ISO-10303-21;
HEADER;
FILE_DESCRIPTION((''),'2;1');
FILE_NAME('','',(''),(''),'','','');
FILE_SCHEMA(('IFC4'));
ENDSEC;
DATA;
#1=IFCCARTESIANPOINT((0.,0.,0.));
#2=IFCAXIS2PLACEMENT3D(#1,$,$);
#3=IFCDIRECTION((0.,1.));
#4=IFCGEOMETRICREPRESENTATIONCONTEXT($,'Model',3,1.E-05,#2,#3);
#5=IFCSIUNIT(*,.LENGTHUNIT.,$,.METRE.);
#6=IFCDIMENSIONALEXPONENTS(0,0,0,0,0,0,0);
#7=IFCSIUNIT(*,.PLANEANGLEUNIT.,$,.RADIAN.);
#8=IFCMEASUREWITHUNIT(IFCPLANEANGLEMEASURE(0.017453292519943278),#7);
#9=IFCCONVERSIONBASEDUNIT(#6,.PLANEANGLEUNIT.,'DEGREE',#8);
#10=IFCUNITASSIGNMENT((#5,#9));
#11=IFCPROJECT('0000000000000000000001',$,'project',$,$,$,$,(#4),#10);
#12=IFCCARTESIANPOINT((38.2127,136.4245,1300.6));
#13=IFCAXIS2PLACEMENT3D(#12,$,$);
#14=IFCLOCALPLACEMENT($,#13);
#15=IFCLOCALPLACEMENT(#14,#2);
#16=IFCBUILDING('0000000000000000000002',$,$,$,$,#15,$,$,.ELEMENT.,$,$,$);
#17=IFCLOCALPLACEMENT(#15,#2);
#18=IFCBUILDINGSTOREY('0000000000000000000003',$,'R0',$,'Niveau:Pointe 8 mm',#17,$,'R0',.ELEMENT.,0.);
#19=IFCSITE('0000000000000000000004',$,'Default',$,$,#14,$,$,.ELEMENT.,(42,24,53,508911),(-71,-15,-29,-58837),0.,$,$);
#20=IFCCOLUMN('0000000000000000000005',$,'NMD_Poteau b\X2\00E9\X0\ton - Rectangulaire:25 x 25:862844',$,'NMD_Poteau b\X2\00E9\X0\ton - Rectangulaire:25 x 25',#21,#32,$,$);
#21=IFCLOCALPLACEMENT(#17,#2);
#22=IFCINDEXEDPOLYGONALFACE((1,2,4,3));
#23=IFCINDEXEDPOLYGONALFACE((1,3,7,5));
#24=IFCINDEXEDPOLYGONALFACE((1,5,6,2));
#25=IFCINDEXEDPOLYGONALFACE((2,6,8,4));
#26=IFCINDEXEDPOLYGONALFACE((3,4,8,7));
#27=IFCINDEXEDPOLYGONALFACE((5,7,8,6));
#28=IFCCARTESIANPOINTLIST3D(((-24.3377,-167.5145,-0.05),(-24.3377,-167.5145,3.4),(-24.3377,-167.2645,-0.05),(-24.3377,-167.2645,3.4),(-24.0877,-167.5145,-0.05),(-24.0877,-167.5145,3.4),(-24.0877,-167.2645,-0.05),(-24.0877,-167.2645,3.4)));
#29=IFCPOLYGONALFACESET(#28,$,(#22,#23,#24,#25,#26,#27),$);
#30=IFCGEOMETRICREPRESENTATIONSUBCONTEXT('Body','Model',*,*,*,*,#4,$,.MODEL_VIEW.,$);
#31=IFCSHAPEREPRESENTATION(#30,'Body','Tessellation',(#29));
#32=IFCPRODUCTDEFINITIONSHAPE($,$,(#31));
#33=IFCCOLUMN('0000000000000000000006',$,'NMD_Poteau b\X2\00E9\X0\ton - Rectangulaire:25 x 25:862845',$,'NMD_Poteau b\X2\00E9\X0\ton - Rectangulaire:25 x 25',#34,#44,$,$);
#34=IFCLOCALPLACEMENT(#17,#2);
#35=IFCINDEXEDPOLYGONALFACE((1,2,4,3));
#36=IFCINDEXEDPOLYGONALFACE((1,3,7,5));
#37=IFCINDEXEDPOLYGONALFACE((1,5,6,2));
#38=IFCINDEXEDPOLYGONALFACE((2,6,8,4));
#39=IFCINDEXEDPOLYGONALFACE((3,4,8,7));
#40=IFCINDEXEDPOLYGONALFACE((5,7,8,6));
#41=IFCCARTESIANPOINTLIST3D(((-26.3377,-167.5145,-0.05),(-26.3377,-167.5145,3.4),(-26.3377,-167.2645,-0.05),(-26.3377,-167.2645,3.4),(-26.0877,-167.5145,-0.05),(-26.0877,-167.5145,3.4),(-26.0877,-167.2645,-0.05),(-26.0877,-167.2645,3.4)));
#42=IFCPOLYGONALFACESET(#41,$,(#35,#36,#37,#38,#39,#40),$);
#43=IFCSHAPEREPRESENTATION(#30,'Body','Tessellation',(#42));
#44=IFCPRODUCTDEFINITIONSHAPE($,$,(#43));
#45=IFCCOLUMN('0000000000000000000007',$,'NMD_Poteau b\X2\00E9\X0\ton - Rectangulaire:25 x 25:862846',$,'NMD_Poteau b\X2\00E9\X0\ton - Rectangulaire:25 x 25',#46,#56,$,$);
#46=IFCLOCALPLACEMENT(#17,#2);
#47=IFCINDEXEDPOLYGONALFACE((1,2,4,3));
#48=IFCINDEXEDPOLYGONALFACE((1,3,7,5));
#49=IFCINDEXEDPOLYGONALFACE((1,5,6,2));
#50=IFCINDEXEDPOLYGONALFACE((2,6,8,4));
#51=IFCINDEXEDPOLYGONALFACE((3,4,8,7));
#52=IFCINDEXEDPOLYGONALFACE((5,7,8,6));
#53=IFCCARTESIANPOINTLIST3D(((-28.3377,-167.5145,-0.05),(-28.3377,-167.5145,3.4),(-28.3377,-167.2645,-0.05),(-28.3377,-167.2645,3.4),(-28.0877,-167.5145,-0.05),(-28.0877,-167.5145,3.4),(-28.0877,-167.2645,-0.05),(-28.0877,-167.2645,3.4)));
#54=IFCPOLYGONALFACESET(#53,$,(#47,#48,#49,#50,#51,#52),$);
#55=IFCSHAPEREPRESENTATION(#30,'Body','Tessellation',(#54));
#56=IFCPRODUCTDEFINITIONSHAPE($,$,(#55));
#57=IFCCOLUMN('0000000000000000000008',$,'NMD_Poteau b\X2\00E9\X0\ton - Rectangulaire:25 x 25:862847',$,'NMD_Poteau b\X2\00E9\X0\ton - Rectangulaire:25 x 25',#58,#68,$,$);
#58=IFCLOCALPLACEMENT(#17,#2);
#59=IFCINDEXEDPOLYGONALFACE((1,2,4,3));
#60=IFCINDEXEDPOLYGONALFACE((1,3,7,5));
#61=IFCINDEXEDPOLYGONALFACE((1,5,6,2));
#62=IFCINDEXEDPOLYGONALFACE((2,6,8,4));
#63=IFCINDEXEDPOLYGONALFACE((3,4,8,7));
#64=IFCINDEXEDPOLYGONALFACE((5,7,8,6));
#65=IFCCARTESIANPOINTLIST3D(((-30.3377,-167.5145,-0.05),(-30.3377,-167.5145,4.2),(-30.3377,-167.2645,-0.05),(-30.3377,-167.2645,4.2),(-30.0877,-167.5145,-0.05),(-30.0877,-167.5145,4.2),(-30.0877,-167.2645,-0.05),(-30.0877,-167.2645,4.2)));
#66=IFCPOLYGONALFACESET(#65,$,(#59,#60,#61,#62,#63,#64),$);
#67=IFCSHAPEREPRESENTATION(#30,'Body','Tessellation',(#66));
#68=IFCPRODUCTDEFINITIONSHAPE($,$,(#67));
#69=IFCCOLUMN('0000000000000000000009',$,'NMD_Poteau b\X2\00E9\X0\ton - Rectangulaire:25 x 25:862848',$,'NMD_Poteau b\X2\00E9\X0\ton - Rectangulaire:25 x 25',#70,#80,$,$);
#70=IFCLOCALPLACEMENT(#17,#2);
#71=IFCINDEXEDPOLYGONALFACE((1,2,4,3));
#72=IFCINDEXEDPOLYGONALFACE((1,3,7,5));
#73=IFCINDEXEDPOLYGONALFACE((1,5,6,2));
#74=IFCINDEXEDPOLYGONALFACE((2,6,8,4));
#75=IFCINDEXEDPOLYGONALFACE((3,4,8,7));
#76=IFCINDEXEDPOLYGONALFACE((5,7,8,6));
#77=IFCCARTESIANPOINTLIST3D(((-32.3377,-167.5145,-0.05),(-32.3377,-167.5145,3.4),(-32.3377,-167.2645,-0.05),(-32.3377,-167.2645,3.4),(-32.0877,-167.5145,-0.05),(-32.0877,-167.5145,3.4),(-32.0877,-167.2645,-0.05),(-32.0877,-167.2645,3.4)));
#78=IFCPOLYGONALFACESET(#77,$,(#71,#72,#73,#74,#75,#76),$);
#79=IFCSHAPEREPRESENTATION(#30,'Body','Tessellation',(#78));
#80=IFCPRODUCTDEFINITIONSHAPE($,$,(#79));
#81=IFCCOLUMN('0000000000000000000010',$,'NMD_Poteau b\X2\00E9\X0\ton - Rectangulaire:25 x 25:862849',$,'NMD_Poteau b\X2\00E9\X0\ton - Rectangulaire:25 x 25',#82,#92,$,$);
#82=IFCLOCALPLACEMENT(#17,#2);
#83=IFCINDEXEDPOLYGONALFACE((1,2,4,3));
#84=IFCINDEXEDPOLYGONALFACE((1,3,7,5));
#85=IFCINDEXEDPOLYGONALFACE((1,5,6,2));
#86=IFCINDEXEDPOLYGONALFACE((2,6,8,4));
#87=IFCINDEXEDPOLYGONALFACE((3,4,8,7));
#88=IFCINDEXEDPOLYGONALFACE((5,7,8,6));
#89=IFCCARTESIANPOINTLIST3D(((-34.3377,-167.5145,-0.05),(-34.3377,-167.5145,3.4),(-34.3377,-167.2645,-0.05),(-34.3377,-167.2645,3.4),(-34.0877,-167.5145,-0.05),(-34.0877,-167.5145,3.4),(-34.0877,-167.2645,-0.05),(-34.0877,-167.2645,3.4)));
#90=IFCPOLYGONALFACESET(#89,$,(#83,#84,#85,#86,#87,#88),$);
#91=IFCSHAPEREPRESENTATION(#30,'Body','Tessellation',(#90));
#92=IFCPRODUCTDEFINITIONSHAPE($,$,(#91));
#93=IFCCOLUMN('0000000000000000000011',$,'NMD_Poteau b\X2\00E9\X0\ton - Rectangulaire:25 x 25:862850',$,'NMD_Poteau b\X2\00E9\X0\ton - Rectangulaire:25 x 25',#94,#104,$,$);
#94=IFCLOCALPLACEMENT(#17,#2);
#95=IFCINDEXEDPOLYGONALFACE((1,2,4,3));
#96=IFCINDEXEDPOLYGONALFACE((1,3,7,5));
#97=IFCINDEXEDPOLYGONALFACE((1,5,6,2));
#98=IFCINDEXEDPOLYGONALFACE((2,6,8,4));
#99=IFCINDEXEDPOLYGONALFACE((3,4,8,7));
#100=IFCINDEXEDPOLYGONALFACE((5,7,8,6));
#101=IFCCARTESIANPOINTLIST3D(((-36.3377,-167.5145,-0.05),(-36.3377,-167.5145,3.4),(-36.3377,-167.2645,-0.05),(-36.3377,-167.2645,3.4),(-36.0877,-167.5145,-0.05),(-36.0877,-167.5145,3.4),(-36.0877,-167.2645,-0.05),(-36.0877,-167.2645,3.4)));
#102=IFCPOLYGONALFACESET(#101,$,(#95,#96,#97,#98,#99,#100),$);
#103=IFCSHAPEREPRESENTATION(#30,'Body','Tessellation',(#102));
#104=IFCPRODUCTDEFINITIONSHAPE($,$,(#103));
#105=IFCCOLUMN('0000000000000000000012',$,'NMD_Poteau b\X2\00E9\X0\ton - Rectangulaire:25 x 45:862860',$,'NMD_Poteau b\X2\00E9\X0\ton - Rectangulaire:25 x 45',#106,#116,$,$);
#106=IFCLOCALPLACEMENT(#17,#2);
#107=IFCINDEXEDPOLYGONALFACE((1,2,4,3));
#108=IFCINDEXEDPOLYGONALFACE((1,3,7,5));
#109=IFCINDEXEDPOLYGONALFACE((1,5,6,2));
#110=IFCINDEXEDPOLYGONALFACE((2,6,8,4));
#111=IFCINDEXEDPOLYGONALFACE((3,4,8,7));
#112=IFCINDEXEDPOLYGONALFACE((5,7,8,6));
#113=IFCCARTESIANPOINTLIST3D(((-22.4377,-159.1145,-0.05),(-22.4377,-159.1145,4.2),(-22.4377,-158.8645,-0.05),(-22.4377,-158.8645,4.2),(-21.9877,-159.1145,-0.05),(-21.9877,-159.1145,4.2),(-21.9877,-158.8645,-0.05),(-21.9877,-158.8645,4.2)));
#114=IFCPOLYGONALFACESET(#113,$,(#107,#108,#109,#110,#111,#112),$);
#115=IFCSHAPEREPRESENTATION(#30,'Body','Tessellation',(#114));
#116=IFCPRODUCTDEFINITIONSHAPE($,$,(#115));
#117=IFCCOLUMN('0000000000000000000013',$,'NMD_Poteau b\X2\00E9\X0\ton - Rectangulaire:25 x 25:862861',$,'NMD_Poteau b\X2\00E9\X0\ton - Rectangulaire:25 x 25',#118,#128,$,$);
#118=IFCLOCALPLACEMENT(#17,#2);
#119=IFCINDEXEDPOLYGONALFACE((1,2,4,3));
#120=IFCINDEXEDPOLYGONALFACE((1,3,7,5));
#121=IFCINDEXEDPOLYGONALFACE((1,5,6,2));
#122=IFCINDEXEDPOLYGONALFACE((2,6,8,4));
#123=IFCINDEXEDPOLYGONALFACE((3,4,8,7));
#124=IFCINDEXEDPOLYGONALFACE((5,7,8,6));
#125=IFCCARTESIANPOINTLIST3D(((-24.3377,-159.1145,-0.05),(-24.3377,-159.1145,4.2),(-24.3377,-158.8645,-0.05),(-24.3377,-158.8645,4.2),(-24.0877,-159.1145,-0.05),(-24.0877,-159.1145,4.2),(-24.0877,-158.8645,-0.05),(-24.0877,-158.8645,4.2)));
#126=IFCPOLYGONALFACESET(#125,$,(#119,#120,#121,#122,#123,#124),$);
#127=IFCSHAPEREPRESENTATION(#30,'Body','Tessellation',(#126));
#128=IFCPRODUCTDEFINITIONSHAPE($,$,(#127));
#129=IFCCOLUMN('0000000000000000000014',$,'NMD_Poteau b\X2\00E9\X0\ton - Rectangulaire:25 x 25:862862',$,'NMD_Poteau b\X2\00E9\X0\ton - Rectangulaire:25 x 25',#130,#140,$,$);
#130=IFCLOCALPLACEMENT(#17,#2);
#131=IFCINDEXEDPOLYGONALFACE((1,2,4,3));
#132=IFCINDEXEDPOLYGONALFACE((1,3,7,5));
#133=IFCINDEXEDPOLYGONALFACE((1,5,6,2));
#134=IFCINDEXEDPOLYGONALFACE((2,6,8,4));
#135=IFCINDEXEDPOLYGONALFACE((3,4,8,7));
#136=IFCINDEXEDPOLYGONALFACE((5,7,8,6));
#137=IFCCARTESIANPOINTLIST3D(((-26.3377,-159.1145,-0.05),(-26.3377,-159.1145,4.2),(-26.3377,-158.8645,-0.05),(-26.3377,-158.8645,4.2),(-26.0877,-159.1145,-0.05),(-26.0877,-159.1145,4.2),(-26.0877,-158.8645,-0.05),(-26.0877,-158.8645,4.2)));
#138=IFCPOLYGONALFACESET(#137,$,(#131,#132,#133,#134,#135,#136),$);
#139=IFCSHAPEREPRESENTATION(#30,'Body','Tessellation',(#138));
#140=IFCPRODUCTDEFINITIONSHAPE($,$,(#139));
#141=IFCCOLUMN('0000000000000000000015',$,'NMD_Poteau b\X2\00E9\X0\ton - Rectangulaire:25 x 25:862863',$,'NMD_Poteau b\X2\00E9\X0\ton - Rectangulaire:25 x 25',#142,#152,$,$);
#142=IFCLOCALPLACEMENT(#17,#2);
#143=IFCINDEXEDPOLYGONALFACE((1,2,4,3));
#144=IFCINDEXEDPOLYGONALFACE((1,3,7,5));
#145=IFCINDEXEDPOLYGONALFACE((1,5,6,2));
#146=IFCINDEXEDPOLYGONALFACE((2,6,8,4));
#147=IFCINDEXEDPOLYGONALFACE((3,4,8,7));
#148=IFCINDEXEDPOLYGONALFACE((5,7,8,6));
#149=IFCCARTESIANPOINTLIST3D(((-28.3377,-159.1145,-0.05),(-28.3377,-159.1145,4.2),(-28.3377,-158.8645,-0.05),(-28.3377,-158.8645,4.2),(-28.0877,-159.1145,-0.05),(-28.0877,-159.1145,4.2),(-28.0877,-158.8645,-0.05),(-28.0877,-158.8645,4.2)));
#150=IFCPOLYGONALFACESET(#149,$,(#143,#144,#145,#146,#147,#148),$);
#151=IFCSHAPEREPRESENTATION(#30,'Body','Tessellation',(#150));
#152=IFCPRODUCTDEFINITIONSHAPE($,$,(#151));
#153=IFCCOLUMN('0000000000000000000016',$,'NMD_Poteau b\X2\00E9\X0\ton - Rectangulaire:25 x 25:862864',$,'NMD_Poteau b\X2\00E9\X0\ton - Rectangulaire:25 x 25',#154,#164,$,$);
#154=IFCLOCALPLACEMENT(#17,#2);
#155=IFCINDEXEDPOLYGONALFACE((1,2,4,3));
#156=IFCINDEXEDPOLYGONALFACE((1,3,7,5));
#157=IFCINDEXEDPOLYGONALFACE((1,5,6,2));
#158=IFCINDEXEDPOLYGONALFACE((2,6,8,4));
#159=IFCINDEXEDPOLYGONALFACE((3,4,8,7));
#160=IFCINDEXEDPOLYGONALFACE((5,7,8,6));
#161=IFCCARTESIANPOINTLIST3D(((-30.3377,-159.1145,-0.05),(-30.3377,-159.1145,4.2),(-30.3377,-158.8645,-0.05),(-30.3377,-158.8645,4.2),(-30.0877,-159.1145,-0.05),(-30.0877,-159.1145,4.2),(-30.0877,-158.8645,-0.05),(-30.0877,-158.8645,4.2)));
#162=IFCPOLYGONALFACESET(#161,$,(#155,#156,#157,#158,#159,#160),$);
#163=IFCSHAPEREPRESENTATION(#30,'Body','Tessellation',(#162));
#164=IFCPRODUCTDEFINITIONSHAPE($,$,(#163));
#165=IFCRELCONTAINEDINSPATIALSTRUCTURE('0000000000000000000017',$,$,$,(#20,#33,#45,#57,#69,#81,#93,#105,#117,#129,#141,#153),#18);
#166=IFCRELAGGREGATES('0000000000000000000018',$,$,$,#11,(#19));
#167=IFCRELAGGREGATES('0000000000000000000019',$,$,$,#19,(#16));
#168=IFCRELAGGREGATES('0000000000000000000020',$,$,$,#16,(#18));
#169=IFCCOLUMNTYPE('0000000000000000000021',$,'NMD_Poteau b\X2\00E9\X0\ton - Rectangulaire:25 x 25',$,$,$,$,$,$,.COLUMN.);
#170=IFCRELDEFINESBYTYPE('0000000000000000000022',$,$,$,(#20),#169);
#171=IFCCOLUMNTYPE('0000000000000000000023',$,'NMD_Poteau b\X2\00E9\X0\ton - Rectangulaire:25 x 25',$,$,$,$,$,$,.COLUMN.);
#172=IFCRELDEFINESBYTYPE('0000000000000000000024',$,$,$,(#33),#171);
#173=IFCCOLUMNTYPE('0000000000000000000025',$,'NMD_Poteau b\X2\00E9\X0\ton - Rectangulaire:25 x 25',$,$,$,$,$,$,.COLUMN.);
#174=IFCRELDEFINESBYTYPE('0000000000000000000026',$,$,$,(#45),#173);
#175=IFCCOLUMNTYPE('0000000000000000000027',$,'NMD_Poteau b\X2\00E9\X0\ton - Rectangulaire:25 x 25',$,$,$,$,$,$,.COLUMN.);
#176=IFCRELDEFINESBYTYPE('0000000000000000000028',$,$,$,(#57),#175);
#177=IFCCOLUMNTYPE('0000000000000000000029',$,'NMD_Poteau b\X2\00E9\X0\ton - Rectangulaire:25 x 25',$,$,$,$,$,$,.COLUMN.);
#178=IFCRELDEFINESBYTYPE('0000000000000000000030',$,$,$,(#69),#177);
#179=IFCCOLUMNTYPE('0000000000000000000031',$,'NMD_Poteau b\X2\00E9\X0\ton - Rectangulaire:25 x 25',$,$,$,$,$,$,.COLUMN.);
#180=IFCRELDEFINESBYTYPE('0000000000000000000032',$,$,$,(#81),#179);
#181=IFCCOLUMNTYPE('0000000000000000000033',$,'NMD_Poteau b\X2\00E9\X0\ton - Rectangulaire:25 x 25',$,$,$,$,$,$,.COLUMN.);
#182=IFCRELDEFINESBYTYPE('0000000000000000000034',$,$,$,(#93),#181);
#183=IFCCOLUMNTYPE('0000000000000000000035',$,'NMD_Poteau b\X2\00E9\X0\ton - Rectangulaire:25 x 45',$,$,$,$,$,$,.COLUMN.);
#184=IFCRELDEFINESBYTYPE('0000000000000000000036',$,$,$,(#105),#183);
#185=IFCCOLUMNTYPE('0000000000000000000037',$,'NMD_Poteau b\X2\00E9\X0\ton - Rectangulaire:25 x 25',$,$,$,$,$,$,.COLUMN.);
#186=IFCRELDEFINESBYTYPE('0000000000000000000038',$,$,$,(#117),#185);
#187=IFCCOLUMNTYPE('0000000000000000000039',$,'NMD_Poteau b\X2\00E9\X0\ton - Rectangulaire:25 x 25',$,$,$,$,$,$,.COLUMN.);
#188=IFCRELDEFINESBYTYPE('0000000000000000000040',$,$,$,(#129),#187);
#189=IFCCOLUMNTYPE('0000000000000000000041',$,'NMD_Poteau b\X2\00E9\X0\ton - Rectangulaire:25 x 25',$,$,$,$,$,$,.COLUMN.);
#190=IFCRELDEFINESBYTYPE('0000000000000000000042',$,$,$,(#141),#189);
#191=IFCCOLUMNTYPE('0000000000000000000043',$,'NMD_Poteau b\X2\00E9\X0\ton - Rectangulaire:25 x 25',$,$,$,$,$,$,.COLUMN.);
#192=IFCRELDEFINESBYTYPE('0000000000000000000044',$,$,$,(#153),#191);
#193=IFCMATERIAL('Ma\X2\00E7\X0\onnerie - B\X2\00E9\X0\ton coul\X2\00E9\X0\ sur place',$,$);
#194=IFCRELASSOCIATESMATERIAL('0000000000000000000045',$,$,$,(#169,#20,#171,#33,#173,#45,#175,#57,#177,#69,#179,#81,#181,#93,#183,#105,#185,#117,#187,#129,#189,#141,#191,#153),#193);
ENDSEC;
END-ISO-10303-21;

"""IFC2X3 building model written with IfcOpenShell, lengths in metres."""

from ifc_helpers import new_model, entity, si_unit, converted_unit, direction, frame, frame_2d, origin, place, context, subcontext, project, spatial, rectangle, extrude, source, transform, mapped, material, type_object, type_shapes, element, save


model = new_model("IFC2X3")

# Units and contexts
model_context = context("Model", 3, precision=1e-05, world=origin(), true_north=direction((0.0, 1.0)))
body_context = subcontext(model_context, "Body", "Model", "MODEL_VIEW")
ifc_project = project(units=[si_unit("LENGTHUNIT", "METRE"), converted_unit("PLANEANGLEUNIT", "DEGREE", entity("IfcPlaneAngleMeasure", 0.017453292519943278), si_unit("PLANEANGLEUNIT", "RADIAN"), dimensions=[0, 0, 0, 0, 0, 0, 0])], contexts=[model_context])

# Site, building, storey
site_placement = place(None, frame((38.2127, 136.4245, 1300.6)))
site = spatial("IfcSite", under=ifc_project, at=site_placement, Name="Default", CompositionType="ELEMENT", RefLatitude=(42, 24, 53, 508911), RefLongitude=(-71, -15, -29, -58837), RefElevation=0.0)
building_placement = place(site_placement, origin())
building = spatial("IfcBuilding", under=site, at=building_placement, CompositionType="ELEMENT")
storey_placement = place(building_placement, origin())
storey = spatial("IfcBuildingStorey", under=building, at=storey_placement, Name="R0", ObjectType="Niveau:Pointe 8 mm", LongName="R0", CompositionType="ELEMENT", Elevation=0.0)

# Columns
ifc_material = material(Name="Maçonnerie - Béton coulé sur place")
column_type_1 = type_object("IfcColumnType", Name="NMD_Poteau béton - Rectangulaire:25 x 25", PredefinedType="COLUMN", material=ifc_material)
shared_shape_1 = source(origin(), body_context, "Body", "SweptSolid", [
    extrude(rectangle(XDim=0.25, YDim=0.25, at=frame_2d((0.0, 0.0), x_axis=(1.0, 0.0))), frame((-24.2127, -167.3895, -0.05), z_axis=(0.0, 0.0, 1.0), x_axis=(-1.0, 0.0, 0.0)), (0.0, 0.0, 1.0), 3.45),
])
type_shapes(column_type_1, [shared_shape_1])
column_1_placement = place(storey_placement, origin())
element("IfcColumn", 1, at=column_1_placement, inside=storey, type_object=column_type_1, material=ifc_material, Name="NMD_Poteau béton - Rectangulaire:25 x 25:862844", ObjectType="NMD_Poteau béton - Rectangulaire:25 x 25", context=body_context, shape_type="MappedRepresentation", body=[
    mapped(shared_shape_1, transform((0.0, 0.0, 0.0), scale=1.0)),
])
column_type_2 = type_object("IfcColumnType", Name="NMD_Poteau béton - Rectangulaire:25 x 25", PredefinedType="COLUMN", material=ifc_material)
shared_shape_2 = source(origin(), body_context, "Body", "SweptSolid", [
    extrude(rectangle(XDim=0.25, YDim=0.25, at=frame_2d((0.0, 0.0), x_axis=(1.0, 0.0))), frame((-26.2127, -167.3895, -0.05), z_axis=(0.0, 0.0, 1.0), x_axis=(-1.0, 0.0, 0.0)), (0.0, 0.0, 1.0), 3.45),
])
type_shapes(column_type_2, [shared_shape_2])
column_2_placement = place(storey_placement, origin())
element("IfcColumn", 2, at=column_2_placement, inside=storey, type_object=column_type_2, material=ifc_material, Name="NMD_Poteau béton - Rectangulaire:25 x 25:862845", ObjectType="NMD_Poteau béton - Rectangulaire:25 x 25", context=body_context, shape_type="MappedRepresentation", body=[
    mapped(shared_shape_2, transform((0.0, 0.0, 0.0), scale=1.0)),
])
column_type_3 = type_object("IfcColumnType", Name="NMD_Poteau béton - Rectangulaire:25 x 25", PredefinedType="COLUMN", material=ifc_material)
shared_shape_3 = source(origin(), body_context, "Body", "SweptSolid", [
    extrude(rectangle(XDim=0.25, YDim=0.25, at=frame_2d((0.0, 0.0), x_axis=(1.0, 0.0))), frame((-28.2127, -167.3895, -0.05), z_axis=(0.0, 0.0, 1.0), x_axis=(-1.0, 0.0, 0.0)), (0.0, 0.0, 1.0), 3.45),
])
type_shapes(column_type_3, [shared_shape_3])
column_3_placement = place(storey_placement, origin())
element("IfcColumn", 3, at=column_3_placement, inside=storey, type_object=column_type_3, material=ifc_material, Name="NMD_Poteau béton - Rectangulaire:25 x 25:862846", ObjectType="NMD_Poteau béton - Rectangulaire:25 x 25", context=body_context, shape_type="MappedRepresentation", body=[
    mapped(shared_shape_3, transform((0.0, 0.0, 0.0), scale=1.0)),
])
column_type_4 = type_object("IfcColumnType", Name="NMD_Poteau béton - Rectangulaire:25 x 25", PredefinedType="COLUMN", material=ifc_material)
shared_shape_4 = source(origin(), body_context, "Body", "SweptSolid", [
    extrude(rectangle(XDim=0.25, YDim=0.25, at=frame_2d((0.0, 0.0), x_axis=(1.0, 0.0))), frame((-30.2127, -167.3895, -0.05), z_axis=(0.0, 0.0, 1.0), x_axis=(-1.0, 0.0, 0.0)), (0.0, 0.0, 1.0), 4.25),
])
type_shapes(column_type_4, [shared_shape_4])
column_4_placement = place(storey_placement, origin())
element("IfcColumn", 4, at=column_4_placement, inside=storey, type_object=column_type_4, material=ifc_material, Name="NMD_Poteau béton - Rectangulaire:25 x 25:862847", ObjectType="NMD_Poteau béton - Rectangulaire:25 x 25", context=body_context, shape_type="MappedRepresentation", body=[
    mapped(shared_shape_4, transform((0.0, 0.0, 0.0), scale=1.0)),
])
column_type_5 = type_object("IfcColumnType", Name="NMD_Poteau béton - Rectangulaire:25 x 25", PredefinedType="COLUMN", material=ifc_material)
shared_shape_5 = source(origin(), body_context, "Body", "SweptSolid", [
    extrude(rectangle(XDim=0.25, YDim=0.25, at=frame_2d((0.0, 0.0), x_axis=(1.0, 0.0))), frame((-32.2127, -167.3895, -0.05), z_axis=(0.0, 0.0, 1.0), x_axis=(-1.0, 0.0, 0.0)), (0.0, 0.0, 1.0), 3.45),
])
type_shapes(column_type_5, [shared_shape_5])
column_5_placement = place(storey_placement, origin())
element("IfcColumn", 5, at=column_5_placement, inside=storey, type_object=column_type_5, material=ifc_material, Name="NMD_Poteau béton - Rectangulaire:25 x 25:862848", ObjectType="NMD_Poteau béton - Rectangulaire:25 x 25", context=body_context, shape_type="MappedRepresentation", body=[
    mapped(shared_shape_5, transform((0.0, 0.0, 0.0), scale=1.0)),
])
column_type_6 = type_object("IfcColumnType", Name="NMD_Poteau béton - Rectangulaire:25 x 25", PredefinedType="COLUMN", material=ifc_material)
shared_shape_6 = source(origin(), body_context, "Body", "SweptSolid", [
    extrude(rectangle(XDim=0.25, YDim=0.25, at=frame_2d((0.0, 0.0), x_axis=(1.0, 0.0))), frame((-34.2127, -167.3895, -0.05), z_axis=(0.0, 0.0, 1.0), x_axis=(-1.0, 0.0, 0.0)), (0.0, 0.0, 1.0), 3.45),
])
type_shapes(column_type_6, [shared_shape_6])
column_6_placement = place(storey_placement, origin())
element("IfcColumn", 6, at=column_6_placement, inside=storey, type_object=column_type_6, material=ifc_material, Name="NMD_Poteau béton - Rectangulaire:25 x 25:862849", ObjectType="NMD_Poteau béton - Rectangulaire:25 x 25", context=body_context, shape_type="MappedRepresentation", body=[
    mapped(shared_shape_6, transform((0.0, 0.0, 0.0), scale=1.0)),
])
column_type_7 = type_object("IfcColumnType", Name="NMD_Poteau béton - Rectangulaire:25 x 25", PredefinedType="COLUMN", material=ifc_material)
shared_shape_7 = source(origin(), body_context, "Body", "SweptSolid", [
    extrude(rectangle(XDim=0.25, YDim=0.25, at=frame_2d((0.0, 0.0), x_axis=(1.0, 0.0))), frame((-36.2127, -167.3895, -0.05), z_axis=(0.0, 0.0, 1.0), x_axis=(-1.0, 0.0, 0.0)), (0.0, 0.0, 1.0), 3.45),
])
type_shapes(column_type_7, [shared_shape_7])
column_7_placement = place(storey_placement, origin())
element("IfcColumn", 7, at=column_7_placement, inside=storey, type_object=column_type_7, material=ifc_material, Name="NMD_Poteau béton - Rectangulaire:25 x 25:862850", ObjectType="NMD_Poteau béton - Rectangulaire:25 x 25", context=body_context, shape_type="MappedRepresentation", body=[
    mapped(shared_shape_7, transform((0.0, 0.0, 0.0), scale=1.0)),
])
column_type_8 = type_object("IfcColumnType", Name="NMD_Poteau béton - Rectangulaire:25 x 45", PredefinedType="COLUMN", material=ifc_material)
shared_shape_8 = source(origin(), body_context, "Body", "SweptSolid", [
    extrude(rectangle(XDim=0.25, YDim=0.45, at=frame_2d((0.0, 0.0), x_axis=(1.0, 0.0))), frame((-22.2127, -158.9895, -0.05), z_axis=(0.0, 0.0, 1.0), x_axis=(0.0, -1.0, 0.0)), (0.0, 0.0, 1.0), 4.25),
])
type_shapes(column_type_8, [shared_shape_8])
column_8_placement = place(storey_placement, origin())
element("IfcColumn", 8, at=column_8_placement, inside=storey, type_object=column_type_8, material=ifc_material, Name="NMD_Poteau béton - Rectangulaire:25 x 45:862860", ObjectType="NMD_Poteau béton - Rectangulaire:25 x 45", context=body_context, shape_type="MappedRepresentation", body=[
    mapped(shared_shape_8, transform((0.0, 0.0, 0.0), scale=1.0)),
])
column_type_9 = type_object("IfcColumnType", Name="NMD_Poteau béton - Rectangulaire:25 x 25", PredefinedType="COLUMN", material=ifc_material)
shared_shape_9 = source(origin(), body_context, "Body", "SweptSolid", [
    extrude(rectangle(XDim=0.25, YDim=0.25, at=frame_2d((0.0, 0.0), x_axis=(1.0, 0.0))), frame((-24.2127, -158.9895, -0.05), z_axis=(0.0, 0.0, 1.0), x_axis=(-1.0, 0.0, 0.0)), (0.0, 0.0, 1.0), 4.25),
])
type_shapes(column_type_9, [shared_shape_9])
column_9_placement = place(storey_placement, origin())
element("IfcColumn", 9, at=column_9_placement, inside=storey, type_object=column_type_9, material=ifc_material, Name="NMD_Poteau béton - Rectangulaire:25 x 25:862861", ObjectType="NMD_Poteau béton - Rectangulaire:25 x 25", context=body_context, shape_type="MappedRepresentation", body=[
    mapped(shared_shape_9, transform((0.0, 0.0, 0.0), scale=1.0)),
])
column_type_10 = type_object("IfcColumnType", Name="NMD_Poteau béton - Rectangulaire:25 x 25", PredefinedType="COLUMN", material=ifc_material)
shared_shape_10 = source(origin(), body_context, "Body", "SweptSolid", [
    extrude(rectangle(XDim=0.25, YDim=0.25, at=frame_2d((0.0, 0.0), x_axis=(1.0, 0.0))), frame((-26.2127, -158.9895, -0.05), z_axis=(0.0, 0.0, 1.0), x_axis=(-1.0, 0.0, 0.0)), (0.0, 0.0, 1.0), 4.25),
])
type_shapes(column_type_10, [shared_shape_10])
column_10_placement = place(storey_placement, origin())
element("IfcColumn", 10, at=column_10_placement, inside=storey, type_object=column_type_10, material=ifc_material, Name="NMD_Poteau béton - Rectangulaire:25 x 25:862862", ObjectType="NMD_Poteau béton - Rectangulaire:25 x 25", context=body_context, shape_type="MappedRepresentation", body=[
    mapped(shared_shape_10, transform((0.0, 0.0, 0.0), scale=1.0)),
])
column_type_11 = type_object("IfcColumnType", Name="NMD_Poteau béton - Rectangulaire:25 x 25", PredefinedType="COLUMN", material=ifc_material)
shared_shape_11 = source(origin(), body_context, "Body", "SweptSolid", [
    extrude(rectangle(XDim=0.25, YDim=0.25, at=frame_2d((0.0, 0.0), x_axis=(1.0, 0.0))), frame((-28.2127, -158.9895, -0.05), z_axis=(0.0, 0.0, 1.0), x_axis=(-1.0, 0.0, 0.0)), (0.0, 0.0, 1.0), 4.25),
])
type_shapes(column_type_11, [shared_shape_11])
column_11_placement = place(storey_placement, origin())
element("IfcColumn", 11, at=column_11_placement, inside=storey, type_object=column_type_11, material=ifc_material, Name="NMD_Poteau béton - Rectangulaire:25 x 25:862863", ObjectType="NMD_Poteau béton - Rectangulaire:25 x 25", context=body_context, shape_type="MappedRepresentation", body=[
    mapped(shared_shape_11, transform((0.0, 0.0, 0.0), scale=1.0)),
])
column_type_12 = type_object("IfcColumnType", Name="NMD_Poteau béton - Rectangulaire:25 x 25", PredefinedType="COLUMN", material=ifc_material)
shared_shape_12 = source(origin(), body_context, "Body", "SweptSolid", [
    extrude(rectangle(XDim=0.25, YDim=0.25, at=frame_2d((0.0, 0.0), x_axis=(1.0, 0.0))), frame((-30.2127, -158.9895, -0.05), z_axis=(0.0, 0.0, 1.0), x_axis=(-1.0, 0.0, 0.0)), (0.0, 0.0, 1.0), 4.25),
])
type_shapes(column_type_12, [shared_shape_12])
column_12_placement = place(storey_placement, origin())
element("IfcColumn", 12, at=column_12_placement, inside=storey, type_object=column_type_12, material=ifc_material, Name="NMD_Poteau béton - Rectangulaire:25 x 25:862864", ObjectType="NMD_Poteau béton - Rectangulaire:25 x 25", context=body_context, shape_type="MappedRepresentation", body=[
    mapped(shared_shape_12, transform((0.0, 0.0, 0.0), scale=1.0)),
])

save(model, "model.ifc")
